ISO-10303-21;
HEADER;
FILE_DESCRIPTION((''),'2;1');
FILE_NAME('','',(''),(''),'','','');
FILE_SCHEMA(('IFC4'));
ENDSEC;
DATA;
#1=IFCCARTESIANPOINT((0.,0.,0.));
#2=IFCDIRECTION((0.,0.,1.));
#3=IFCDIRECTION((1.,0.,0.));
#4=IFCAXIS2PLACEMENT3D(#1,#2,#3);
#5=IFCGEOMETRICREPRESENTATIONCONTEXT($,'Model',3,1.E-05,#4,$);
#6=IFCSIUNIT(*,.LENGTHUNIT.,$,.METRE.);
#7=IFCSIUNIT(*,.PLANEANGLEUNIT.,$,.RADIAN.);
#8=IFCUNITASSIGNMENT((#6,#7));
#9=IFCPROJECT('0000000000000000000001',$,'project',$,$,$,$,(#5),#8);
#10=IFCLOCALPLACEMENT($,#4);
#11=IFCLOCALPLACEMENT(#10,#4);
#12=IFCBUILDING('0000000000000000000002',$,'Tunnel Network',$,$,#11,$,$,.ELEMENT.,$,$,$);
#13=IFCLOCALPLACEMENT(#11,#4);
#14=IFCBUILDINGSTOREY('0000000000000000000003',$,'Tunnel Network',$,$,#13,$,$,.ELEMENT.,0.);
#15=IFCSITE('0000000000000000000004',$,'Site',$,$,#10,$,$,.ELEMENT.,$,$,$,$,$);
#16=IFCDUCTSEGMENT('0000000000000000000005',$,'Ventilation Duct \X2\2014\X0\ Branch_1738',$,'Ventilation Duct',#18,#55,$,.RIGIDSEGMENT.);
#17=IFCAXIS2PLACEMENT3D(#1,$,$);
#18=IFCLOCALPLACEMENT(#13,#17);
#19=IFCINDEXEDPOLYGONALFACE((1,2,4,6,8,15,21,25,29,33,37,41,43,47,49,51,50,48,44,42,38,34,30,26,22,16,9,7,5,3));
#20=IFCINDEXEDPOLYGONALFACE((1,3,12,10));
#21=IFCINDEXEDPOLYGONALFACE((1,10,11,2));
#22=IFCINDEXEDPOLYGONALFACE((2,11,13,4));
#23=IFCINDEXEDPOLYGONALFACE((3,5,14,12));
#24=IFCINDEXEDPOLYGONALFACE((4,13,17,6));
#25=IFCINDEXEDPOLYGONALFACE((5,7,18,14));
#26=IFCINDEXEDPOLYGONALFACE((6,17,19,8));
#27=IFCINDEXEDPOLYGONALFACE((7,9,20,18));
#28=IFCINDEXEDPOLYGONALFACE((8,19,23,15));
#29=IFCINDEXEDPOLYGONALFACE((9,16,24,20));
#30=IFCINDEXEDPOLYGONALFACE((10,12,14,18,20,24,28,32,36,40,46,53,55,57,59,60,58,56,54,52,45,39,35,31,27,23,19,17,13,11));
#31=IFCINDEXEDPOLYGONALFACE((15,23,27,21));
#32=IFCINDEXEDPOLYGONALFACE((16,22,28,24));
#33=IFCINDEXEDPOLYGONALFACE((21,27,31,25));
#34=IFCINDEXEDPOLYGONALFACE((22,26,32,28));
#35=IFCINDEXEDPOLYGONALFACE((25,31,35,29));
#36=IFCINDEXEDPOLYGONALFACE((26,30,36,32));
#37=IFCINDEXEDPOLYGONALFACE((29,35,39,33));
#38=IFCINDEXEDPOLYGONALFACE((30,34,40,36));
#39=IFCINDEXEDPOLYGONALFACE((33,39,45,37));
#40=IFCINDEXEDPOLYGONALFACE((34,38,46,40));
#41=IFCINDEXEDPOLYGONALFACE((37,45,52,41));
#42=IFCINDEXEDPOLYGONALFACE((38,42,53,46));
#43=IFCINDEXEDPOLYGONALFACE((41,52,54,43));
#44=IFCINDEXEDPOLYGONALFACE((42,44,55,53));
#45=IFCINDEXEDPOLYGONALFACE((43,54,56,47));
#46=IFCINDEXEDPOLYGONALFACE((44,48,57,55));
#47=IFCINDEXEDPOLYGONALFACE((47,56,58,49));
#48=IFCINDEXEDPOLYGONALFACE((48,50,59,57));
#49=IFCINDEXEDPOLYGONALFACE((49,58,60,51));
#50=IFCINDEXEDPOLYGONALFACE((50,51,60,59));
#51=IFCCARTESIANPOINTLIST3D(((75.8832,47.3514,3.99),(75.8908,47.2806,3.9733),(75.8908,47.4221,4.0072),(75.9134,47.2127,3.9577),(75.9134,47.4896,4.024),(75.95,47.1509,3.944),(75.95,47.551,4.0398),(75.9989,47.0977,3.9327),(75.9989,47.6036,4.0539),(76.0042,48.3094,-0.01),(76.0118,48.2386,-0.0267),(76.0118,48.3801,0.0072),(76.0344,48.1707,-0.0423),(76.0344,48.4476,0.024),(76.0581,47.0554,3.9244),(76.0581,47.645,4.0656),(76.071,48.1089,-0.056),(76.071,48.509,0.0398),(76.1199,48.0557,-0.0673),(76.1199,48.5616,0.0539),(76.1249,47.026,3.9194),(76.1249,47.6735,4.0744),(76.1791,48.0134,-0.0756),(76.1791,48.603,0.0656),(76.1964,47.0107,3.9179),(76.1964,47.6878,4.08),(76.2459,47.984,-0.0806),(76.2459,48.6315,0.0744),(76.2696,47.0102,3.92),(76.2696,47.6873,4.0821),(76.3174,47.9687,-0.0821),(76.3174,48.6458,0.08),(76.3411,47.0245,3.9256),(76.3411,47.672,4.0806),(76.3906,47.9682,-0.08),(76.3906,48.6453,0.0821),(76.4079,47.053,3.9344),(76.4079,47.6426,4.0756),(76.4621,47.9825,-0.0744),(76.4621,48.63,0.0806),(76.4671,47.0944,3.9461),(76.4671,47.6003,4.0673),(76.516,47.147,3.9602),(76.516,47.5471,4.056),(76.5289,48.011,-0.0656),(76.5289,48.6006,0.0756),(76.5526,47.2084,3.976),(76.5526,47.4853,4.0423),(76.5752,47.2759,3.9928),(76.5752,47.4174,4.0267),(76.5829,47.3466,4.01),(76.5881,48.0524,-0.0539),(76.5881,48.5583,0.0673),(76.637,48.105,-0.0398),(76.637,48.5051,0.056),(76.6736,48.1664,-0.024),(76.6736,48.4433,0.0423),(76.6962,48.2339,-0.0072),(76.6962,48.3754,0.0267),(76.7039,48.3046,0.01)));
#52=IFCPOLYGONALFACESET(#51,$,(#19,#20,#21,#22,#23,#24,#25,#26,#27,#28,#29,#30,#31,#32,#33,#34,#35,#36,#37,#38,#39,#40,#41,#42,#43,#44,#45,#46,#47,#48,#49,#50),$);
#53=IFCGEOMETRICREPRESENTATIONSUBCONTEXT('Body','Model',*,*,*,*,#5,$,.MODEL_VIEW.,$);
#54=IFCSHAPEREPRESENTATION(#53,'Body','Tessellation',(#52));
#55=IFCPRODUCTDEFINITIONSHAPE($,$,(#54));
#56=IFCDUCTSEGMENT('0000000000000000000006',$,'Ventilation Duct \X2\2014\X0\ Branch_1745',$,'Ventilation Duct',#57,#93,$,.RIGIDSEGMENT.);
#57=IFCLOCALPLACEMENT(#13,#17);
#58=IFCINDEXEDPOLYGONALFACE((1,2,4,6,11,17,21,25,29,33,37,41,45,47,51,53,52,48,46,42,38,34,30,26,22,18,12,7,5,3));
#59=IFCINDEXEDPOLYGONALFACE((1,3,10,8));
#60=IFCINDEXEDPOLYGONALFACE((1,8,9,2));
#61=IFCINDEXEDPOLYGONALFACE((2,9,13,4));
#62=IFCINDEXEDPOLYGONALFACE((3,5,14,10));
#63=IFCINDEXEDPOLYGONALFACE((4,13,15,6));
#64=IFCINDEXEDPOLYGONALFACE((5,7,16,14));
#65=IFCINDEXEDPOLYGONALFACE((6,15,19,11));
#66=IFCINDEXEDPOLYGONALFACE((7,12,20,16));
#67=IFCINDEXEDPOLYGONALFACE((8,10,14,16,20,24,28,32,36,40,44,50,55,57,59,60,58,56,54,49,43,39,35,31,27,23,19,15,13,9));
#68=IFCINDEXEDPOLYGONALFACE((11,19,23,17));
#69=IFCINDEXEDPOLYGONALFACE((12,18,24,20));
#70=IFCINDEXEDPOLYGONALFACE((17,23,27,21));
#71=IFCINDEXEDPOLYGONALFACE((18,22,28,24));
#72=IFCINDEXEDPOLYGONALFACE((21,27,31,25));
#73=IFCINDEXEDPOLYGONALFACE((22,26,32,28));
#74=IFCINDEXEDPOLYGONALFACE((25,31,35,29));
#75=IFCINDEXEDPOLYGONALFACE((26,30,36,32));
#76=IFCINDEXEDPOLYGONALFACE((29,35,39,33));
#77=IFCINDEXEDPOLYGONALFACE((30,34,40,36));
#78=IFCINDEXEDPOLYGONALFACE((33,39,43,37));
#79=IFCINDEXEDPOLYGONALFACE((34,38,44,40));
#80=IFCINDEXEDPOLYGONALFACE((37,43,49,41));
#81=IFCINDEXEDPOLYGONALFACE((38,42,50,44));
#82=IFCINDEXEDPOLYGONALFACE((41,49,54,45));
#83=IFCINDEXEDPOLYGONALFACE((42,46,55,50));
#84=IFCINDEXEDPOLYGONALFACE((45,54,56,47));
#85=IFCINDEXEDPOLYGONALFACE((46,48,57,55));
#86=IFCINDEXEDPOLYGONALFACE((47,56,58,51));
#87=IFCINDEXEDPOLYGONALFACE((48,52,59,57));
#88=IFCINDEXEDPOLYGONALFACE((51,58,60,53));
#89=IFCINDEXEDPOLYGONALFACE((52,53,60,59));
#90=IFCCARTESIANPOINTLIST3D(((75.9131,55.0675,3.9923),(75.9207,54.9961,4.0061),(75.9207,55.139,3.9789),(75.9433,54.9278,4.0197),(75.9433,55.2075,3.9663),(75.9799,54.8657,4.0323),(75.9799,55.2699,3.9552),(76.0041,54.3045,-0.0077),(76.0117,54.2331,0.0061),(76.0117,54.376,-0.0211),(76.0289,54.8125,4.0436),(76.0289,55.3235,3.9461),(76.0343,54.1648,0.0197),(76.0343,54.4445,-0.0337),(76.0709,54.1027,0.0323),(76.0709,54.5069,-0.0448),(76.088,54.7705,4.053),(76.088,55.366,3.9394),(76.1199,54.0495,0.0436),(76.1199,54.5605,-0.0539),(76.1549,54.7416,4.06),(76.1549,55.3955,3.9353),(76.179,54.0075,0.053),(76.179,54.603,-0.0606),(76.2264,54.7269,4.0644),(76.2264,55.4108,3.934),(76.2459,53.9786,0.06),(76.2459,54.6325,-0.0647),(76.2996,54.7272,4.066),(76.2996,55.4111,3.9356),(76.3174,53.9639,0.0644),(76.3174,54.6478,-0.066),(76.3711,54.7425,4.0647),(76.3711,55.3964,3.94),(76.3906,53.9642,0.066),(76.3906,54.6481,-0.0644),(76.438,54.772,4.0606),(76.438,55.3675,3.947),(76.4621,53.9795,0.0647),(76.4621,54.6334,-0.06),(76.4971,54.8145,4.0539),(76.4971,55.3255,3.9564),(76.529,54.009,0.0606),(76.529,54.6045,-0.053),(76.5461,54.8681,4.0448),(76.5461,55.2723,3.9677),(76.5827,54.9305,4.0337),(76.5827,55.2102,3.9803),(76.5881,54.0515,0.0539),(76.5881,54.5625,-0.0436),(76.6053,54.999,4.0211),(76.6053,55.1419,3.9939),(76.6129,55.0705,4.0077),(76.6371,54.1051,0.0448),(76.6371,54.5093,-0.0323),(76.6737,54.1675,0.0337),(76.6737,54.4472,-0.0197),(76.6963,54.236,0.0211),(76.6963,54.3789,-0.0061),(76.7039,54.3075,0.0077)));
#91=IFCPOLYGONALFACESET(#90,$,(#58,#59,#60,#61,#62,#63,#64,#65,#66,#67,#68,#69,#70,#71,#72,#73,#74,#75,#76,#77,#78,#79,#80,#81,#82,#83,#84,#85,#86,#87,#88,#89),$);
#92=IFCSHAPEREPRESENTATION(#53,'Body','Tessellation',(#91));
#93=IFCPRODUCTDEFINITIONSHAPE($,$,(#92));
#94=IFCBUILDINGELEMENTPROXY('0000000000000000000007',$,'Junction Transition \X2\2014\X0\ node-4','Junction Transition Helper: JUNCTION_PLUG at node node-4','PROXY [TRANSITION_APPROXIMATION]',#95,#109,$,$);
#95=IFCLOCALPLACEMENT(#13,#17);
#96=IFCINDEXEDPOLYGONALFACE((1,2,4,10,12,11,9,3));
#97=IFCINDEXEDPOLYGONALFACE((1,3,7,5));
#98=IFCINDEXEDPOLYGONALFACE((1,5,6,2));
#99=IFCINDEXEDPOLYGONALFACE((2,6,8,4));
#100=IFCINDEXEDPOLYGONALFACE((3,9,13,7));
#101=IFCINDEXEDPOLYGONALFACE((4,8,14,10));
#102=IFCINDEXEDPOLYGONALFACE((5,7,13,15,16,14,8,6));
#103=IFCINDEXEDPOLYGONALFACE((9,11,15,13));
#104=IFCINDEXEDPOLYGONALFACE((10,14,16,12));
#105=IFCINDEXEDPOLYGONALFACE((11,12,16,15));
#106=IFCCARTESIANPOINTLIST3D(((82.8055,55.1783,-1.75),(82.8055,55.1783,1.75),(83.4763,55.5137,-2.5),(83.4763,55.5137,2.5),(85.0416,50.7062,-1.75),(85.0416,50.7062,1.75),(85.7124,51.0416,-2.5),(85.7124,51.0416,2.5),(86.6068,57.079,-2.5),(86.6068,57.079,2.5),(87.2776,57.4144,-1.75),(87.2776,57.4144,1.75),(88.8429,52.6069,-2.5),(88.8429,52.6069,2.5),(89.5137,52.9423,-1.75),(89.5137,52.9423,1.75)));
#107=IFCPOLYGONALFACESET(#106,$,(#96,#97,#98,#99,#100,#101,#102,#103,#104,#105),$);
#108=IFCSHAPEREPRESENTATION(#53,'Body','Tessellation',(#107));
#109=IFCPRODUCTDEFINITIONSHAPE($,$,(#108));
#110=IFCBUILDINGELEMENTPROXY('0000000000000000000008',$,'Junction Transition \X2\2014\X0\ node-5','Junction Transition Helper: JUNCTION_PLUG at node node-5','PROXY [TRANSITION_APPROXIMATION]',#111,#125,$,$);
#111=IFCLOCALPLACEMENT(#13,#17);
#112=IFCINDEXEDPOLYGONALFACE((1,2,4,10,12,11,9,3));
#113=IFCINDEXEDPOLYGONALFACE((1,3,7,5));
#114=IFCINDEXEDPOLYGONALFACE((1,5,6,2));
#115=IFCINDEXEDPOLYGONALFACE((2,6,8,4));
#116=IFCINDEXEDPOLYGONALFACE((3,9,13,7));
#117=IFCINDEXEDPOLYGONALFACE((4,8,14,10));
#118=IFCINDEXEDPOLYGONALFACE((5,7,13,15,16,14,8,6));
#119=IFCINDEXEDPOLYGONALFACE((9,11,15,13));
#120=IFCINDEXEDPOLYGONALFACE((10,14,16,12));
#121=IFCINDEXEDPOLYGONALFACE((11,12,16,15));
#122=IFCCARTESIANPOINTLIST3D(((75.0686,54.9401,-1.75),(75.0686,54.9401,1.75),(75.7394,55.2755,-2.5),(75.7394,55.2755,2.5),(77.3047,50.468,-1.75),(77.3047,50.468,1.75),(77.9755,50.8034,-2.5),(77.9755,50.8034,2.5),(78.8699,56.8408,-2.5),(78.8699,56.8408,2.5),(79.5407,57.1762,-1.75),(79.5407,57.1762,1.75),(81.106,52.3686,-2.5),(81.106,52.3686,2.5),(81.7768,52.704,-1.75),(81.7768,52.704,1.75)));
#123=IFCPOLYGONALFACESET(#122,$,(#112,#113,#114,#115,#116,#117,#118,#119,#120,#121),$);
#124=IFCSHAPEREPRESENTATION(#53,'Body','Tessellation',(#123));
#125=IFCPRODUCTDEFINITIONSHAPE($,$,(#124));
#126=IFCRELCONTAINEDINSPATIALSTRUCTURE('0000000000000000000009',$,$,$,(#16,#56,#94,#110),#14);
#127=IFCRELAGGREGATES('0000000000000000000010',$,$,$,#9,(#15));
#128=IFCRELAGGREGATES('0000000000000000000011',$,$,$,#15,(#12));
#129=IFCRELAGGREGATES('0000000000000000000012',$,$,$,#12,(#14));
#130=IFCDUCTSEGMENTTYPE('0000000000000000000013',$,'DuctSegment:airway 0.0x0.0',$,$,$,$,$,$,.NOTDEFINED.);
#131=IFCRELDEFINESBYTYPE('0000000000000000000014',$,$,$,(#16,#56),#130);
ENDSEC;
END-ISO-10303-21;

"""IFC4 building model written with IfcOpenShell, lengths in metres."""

from ifc_helpers import new_model, si_unit, frame, origin_with_axes, origin_2d_with_axis, place, context, subcontext, project, spatial, polyline, circle, outline, extrude, type_object, element, save


model = new_model("IFC4")

# Units and contexts
model_context = context("Model", 3, precision=1e-05, world=origin_with_axes())
body_context = subcontext(model_context, "Body", "Model", "MODEL_VIEW")
ifc_project = project(units=[si_unit("LENGTHUNIT", "METRE"), si_unit("PLANEANGLEUNIT", "RADIAN")], contexts=[model_context])

# Site, building, storey
site_placement = place(None, origin_with_axes())
site = spatial("IfcSite", under=ifc_project, at=site_placement, Name="Site", CompositionType="ELEMENT")
building_placement = place(site_placement, origin_with_axes())
building = spatial("IfcBuilding", under=site, at=building_placement, Name="Tunnel Network", CompositionType="ELEMENT")
storey_placement = place(building_placement, origin_with_axes())
storey = spatial("IfcBuildingStorey", under=building, at=storey_placement, Name="Tunnel Network", CompositionType="ELEMENT", Elevation=0.0)

# Duct segments
duct_segment_type_1 = type_object("IfcDuctSegmentType", Name="DuctSegment:airway 0.0x0.0")
duct_segment_1_placement = place(storey_placement, frame((76.233, 47.349, 4.0), z_axis=(0.029405, 0.232812, -0.972077), x_axis=(0.999568, -0.006849, 0.028597)))
element("IfcDuctSegment", 1, at=duct_segment_1_placement, inside=storey, type_object=duct_segment_type_1, Name="Ventilation Duct — Branch_1738", ObjectType="Ventilation Duct", PredefinedType="RIGIDSEGMENT", context=body_context, shape_type="SweptSolid", body=[
    extrude(circle(Radius=0.35, at=origin_2d_with_axis()), origin_with_axes(), (0.0, 0.0, 1.0), 4.1149),
])
duct_segment_2_placement = place(storey_placement, frame((76.354, 54.306, 0.0), z_axis=(-0.022342, 0.187324, 0.982044), x_axis=(0.99975, 0.004186, 0.021946)))
element("IfcDuctSegment", 2, at=duct_segment_2_placement, inside=storey, type_object=duct_segment_type_1, Name="Ventilation Duct — Branch_1745", ObjectType="Ventilation Duct", PredefinedType="RIGIDSEGMENT", context=body_context, shape_type="SweptSolid", body=[
    extrude(circle(Radius=0.35, at=origin_2d_with_axis()), origin_with_axes(), (0.0, 0.0, 1.0), 4.0731),
])

# Building element proxies
for number, where, z_axis, x_axis, name, description in (
    (3, (87.2776, 51.8242, 0.0), (-0.447214, 0.894427, 0.0), (0.894427, 0.447214, 0.0), "Junction Transition — node-4", "Junction Transition Helper: JUNCTION_PLUG at node node-4"),
    (4, (79.5407, 51.586, 0.0), (-0.447214, 0.894427, 0.0), (0.894427, 0.447214, 0.0), "Junction Transition — node-5", "Junction Transition Helper: JUNCTION_PLUG at node node-5"),
):
    element("IfcBuildingElementProxy", number, at=place(storey_placement, frame(where, z_axis=z_axis, x_axis=x_axis)), inside=storey, Name=name, Description=description, ObjectType="PROXY [TRANSITION_APPROXIMATION]", context=body_context, shape_type="SweptSolid", body=[
        extrude(outline(polyline([(1.75, 2.5), (2.5, 1.75), (2.5, -1.75), (1.75, -2.5), (-1.75, -2.5), (-2.5, -1.75), (-2.5, 1.75), (-1.75, 2.5), (1.75, 2.5)])), origin_with_axes(), (0.0, 0.0, 1.0), 5.0),
    ])

save(model, "model.ifc")
